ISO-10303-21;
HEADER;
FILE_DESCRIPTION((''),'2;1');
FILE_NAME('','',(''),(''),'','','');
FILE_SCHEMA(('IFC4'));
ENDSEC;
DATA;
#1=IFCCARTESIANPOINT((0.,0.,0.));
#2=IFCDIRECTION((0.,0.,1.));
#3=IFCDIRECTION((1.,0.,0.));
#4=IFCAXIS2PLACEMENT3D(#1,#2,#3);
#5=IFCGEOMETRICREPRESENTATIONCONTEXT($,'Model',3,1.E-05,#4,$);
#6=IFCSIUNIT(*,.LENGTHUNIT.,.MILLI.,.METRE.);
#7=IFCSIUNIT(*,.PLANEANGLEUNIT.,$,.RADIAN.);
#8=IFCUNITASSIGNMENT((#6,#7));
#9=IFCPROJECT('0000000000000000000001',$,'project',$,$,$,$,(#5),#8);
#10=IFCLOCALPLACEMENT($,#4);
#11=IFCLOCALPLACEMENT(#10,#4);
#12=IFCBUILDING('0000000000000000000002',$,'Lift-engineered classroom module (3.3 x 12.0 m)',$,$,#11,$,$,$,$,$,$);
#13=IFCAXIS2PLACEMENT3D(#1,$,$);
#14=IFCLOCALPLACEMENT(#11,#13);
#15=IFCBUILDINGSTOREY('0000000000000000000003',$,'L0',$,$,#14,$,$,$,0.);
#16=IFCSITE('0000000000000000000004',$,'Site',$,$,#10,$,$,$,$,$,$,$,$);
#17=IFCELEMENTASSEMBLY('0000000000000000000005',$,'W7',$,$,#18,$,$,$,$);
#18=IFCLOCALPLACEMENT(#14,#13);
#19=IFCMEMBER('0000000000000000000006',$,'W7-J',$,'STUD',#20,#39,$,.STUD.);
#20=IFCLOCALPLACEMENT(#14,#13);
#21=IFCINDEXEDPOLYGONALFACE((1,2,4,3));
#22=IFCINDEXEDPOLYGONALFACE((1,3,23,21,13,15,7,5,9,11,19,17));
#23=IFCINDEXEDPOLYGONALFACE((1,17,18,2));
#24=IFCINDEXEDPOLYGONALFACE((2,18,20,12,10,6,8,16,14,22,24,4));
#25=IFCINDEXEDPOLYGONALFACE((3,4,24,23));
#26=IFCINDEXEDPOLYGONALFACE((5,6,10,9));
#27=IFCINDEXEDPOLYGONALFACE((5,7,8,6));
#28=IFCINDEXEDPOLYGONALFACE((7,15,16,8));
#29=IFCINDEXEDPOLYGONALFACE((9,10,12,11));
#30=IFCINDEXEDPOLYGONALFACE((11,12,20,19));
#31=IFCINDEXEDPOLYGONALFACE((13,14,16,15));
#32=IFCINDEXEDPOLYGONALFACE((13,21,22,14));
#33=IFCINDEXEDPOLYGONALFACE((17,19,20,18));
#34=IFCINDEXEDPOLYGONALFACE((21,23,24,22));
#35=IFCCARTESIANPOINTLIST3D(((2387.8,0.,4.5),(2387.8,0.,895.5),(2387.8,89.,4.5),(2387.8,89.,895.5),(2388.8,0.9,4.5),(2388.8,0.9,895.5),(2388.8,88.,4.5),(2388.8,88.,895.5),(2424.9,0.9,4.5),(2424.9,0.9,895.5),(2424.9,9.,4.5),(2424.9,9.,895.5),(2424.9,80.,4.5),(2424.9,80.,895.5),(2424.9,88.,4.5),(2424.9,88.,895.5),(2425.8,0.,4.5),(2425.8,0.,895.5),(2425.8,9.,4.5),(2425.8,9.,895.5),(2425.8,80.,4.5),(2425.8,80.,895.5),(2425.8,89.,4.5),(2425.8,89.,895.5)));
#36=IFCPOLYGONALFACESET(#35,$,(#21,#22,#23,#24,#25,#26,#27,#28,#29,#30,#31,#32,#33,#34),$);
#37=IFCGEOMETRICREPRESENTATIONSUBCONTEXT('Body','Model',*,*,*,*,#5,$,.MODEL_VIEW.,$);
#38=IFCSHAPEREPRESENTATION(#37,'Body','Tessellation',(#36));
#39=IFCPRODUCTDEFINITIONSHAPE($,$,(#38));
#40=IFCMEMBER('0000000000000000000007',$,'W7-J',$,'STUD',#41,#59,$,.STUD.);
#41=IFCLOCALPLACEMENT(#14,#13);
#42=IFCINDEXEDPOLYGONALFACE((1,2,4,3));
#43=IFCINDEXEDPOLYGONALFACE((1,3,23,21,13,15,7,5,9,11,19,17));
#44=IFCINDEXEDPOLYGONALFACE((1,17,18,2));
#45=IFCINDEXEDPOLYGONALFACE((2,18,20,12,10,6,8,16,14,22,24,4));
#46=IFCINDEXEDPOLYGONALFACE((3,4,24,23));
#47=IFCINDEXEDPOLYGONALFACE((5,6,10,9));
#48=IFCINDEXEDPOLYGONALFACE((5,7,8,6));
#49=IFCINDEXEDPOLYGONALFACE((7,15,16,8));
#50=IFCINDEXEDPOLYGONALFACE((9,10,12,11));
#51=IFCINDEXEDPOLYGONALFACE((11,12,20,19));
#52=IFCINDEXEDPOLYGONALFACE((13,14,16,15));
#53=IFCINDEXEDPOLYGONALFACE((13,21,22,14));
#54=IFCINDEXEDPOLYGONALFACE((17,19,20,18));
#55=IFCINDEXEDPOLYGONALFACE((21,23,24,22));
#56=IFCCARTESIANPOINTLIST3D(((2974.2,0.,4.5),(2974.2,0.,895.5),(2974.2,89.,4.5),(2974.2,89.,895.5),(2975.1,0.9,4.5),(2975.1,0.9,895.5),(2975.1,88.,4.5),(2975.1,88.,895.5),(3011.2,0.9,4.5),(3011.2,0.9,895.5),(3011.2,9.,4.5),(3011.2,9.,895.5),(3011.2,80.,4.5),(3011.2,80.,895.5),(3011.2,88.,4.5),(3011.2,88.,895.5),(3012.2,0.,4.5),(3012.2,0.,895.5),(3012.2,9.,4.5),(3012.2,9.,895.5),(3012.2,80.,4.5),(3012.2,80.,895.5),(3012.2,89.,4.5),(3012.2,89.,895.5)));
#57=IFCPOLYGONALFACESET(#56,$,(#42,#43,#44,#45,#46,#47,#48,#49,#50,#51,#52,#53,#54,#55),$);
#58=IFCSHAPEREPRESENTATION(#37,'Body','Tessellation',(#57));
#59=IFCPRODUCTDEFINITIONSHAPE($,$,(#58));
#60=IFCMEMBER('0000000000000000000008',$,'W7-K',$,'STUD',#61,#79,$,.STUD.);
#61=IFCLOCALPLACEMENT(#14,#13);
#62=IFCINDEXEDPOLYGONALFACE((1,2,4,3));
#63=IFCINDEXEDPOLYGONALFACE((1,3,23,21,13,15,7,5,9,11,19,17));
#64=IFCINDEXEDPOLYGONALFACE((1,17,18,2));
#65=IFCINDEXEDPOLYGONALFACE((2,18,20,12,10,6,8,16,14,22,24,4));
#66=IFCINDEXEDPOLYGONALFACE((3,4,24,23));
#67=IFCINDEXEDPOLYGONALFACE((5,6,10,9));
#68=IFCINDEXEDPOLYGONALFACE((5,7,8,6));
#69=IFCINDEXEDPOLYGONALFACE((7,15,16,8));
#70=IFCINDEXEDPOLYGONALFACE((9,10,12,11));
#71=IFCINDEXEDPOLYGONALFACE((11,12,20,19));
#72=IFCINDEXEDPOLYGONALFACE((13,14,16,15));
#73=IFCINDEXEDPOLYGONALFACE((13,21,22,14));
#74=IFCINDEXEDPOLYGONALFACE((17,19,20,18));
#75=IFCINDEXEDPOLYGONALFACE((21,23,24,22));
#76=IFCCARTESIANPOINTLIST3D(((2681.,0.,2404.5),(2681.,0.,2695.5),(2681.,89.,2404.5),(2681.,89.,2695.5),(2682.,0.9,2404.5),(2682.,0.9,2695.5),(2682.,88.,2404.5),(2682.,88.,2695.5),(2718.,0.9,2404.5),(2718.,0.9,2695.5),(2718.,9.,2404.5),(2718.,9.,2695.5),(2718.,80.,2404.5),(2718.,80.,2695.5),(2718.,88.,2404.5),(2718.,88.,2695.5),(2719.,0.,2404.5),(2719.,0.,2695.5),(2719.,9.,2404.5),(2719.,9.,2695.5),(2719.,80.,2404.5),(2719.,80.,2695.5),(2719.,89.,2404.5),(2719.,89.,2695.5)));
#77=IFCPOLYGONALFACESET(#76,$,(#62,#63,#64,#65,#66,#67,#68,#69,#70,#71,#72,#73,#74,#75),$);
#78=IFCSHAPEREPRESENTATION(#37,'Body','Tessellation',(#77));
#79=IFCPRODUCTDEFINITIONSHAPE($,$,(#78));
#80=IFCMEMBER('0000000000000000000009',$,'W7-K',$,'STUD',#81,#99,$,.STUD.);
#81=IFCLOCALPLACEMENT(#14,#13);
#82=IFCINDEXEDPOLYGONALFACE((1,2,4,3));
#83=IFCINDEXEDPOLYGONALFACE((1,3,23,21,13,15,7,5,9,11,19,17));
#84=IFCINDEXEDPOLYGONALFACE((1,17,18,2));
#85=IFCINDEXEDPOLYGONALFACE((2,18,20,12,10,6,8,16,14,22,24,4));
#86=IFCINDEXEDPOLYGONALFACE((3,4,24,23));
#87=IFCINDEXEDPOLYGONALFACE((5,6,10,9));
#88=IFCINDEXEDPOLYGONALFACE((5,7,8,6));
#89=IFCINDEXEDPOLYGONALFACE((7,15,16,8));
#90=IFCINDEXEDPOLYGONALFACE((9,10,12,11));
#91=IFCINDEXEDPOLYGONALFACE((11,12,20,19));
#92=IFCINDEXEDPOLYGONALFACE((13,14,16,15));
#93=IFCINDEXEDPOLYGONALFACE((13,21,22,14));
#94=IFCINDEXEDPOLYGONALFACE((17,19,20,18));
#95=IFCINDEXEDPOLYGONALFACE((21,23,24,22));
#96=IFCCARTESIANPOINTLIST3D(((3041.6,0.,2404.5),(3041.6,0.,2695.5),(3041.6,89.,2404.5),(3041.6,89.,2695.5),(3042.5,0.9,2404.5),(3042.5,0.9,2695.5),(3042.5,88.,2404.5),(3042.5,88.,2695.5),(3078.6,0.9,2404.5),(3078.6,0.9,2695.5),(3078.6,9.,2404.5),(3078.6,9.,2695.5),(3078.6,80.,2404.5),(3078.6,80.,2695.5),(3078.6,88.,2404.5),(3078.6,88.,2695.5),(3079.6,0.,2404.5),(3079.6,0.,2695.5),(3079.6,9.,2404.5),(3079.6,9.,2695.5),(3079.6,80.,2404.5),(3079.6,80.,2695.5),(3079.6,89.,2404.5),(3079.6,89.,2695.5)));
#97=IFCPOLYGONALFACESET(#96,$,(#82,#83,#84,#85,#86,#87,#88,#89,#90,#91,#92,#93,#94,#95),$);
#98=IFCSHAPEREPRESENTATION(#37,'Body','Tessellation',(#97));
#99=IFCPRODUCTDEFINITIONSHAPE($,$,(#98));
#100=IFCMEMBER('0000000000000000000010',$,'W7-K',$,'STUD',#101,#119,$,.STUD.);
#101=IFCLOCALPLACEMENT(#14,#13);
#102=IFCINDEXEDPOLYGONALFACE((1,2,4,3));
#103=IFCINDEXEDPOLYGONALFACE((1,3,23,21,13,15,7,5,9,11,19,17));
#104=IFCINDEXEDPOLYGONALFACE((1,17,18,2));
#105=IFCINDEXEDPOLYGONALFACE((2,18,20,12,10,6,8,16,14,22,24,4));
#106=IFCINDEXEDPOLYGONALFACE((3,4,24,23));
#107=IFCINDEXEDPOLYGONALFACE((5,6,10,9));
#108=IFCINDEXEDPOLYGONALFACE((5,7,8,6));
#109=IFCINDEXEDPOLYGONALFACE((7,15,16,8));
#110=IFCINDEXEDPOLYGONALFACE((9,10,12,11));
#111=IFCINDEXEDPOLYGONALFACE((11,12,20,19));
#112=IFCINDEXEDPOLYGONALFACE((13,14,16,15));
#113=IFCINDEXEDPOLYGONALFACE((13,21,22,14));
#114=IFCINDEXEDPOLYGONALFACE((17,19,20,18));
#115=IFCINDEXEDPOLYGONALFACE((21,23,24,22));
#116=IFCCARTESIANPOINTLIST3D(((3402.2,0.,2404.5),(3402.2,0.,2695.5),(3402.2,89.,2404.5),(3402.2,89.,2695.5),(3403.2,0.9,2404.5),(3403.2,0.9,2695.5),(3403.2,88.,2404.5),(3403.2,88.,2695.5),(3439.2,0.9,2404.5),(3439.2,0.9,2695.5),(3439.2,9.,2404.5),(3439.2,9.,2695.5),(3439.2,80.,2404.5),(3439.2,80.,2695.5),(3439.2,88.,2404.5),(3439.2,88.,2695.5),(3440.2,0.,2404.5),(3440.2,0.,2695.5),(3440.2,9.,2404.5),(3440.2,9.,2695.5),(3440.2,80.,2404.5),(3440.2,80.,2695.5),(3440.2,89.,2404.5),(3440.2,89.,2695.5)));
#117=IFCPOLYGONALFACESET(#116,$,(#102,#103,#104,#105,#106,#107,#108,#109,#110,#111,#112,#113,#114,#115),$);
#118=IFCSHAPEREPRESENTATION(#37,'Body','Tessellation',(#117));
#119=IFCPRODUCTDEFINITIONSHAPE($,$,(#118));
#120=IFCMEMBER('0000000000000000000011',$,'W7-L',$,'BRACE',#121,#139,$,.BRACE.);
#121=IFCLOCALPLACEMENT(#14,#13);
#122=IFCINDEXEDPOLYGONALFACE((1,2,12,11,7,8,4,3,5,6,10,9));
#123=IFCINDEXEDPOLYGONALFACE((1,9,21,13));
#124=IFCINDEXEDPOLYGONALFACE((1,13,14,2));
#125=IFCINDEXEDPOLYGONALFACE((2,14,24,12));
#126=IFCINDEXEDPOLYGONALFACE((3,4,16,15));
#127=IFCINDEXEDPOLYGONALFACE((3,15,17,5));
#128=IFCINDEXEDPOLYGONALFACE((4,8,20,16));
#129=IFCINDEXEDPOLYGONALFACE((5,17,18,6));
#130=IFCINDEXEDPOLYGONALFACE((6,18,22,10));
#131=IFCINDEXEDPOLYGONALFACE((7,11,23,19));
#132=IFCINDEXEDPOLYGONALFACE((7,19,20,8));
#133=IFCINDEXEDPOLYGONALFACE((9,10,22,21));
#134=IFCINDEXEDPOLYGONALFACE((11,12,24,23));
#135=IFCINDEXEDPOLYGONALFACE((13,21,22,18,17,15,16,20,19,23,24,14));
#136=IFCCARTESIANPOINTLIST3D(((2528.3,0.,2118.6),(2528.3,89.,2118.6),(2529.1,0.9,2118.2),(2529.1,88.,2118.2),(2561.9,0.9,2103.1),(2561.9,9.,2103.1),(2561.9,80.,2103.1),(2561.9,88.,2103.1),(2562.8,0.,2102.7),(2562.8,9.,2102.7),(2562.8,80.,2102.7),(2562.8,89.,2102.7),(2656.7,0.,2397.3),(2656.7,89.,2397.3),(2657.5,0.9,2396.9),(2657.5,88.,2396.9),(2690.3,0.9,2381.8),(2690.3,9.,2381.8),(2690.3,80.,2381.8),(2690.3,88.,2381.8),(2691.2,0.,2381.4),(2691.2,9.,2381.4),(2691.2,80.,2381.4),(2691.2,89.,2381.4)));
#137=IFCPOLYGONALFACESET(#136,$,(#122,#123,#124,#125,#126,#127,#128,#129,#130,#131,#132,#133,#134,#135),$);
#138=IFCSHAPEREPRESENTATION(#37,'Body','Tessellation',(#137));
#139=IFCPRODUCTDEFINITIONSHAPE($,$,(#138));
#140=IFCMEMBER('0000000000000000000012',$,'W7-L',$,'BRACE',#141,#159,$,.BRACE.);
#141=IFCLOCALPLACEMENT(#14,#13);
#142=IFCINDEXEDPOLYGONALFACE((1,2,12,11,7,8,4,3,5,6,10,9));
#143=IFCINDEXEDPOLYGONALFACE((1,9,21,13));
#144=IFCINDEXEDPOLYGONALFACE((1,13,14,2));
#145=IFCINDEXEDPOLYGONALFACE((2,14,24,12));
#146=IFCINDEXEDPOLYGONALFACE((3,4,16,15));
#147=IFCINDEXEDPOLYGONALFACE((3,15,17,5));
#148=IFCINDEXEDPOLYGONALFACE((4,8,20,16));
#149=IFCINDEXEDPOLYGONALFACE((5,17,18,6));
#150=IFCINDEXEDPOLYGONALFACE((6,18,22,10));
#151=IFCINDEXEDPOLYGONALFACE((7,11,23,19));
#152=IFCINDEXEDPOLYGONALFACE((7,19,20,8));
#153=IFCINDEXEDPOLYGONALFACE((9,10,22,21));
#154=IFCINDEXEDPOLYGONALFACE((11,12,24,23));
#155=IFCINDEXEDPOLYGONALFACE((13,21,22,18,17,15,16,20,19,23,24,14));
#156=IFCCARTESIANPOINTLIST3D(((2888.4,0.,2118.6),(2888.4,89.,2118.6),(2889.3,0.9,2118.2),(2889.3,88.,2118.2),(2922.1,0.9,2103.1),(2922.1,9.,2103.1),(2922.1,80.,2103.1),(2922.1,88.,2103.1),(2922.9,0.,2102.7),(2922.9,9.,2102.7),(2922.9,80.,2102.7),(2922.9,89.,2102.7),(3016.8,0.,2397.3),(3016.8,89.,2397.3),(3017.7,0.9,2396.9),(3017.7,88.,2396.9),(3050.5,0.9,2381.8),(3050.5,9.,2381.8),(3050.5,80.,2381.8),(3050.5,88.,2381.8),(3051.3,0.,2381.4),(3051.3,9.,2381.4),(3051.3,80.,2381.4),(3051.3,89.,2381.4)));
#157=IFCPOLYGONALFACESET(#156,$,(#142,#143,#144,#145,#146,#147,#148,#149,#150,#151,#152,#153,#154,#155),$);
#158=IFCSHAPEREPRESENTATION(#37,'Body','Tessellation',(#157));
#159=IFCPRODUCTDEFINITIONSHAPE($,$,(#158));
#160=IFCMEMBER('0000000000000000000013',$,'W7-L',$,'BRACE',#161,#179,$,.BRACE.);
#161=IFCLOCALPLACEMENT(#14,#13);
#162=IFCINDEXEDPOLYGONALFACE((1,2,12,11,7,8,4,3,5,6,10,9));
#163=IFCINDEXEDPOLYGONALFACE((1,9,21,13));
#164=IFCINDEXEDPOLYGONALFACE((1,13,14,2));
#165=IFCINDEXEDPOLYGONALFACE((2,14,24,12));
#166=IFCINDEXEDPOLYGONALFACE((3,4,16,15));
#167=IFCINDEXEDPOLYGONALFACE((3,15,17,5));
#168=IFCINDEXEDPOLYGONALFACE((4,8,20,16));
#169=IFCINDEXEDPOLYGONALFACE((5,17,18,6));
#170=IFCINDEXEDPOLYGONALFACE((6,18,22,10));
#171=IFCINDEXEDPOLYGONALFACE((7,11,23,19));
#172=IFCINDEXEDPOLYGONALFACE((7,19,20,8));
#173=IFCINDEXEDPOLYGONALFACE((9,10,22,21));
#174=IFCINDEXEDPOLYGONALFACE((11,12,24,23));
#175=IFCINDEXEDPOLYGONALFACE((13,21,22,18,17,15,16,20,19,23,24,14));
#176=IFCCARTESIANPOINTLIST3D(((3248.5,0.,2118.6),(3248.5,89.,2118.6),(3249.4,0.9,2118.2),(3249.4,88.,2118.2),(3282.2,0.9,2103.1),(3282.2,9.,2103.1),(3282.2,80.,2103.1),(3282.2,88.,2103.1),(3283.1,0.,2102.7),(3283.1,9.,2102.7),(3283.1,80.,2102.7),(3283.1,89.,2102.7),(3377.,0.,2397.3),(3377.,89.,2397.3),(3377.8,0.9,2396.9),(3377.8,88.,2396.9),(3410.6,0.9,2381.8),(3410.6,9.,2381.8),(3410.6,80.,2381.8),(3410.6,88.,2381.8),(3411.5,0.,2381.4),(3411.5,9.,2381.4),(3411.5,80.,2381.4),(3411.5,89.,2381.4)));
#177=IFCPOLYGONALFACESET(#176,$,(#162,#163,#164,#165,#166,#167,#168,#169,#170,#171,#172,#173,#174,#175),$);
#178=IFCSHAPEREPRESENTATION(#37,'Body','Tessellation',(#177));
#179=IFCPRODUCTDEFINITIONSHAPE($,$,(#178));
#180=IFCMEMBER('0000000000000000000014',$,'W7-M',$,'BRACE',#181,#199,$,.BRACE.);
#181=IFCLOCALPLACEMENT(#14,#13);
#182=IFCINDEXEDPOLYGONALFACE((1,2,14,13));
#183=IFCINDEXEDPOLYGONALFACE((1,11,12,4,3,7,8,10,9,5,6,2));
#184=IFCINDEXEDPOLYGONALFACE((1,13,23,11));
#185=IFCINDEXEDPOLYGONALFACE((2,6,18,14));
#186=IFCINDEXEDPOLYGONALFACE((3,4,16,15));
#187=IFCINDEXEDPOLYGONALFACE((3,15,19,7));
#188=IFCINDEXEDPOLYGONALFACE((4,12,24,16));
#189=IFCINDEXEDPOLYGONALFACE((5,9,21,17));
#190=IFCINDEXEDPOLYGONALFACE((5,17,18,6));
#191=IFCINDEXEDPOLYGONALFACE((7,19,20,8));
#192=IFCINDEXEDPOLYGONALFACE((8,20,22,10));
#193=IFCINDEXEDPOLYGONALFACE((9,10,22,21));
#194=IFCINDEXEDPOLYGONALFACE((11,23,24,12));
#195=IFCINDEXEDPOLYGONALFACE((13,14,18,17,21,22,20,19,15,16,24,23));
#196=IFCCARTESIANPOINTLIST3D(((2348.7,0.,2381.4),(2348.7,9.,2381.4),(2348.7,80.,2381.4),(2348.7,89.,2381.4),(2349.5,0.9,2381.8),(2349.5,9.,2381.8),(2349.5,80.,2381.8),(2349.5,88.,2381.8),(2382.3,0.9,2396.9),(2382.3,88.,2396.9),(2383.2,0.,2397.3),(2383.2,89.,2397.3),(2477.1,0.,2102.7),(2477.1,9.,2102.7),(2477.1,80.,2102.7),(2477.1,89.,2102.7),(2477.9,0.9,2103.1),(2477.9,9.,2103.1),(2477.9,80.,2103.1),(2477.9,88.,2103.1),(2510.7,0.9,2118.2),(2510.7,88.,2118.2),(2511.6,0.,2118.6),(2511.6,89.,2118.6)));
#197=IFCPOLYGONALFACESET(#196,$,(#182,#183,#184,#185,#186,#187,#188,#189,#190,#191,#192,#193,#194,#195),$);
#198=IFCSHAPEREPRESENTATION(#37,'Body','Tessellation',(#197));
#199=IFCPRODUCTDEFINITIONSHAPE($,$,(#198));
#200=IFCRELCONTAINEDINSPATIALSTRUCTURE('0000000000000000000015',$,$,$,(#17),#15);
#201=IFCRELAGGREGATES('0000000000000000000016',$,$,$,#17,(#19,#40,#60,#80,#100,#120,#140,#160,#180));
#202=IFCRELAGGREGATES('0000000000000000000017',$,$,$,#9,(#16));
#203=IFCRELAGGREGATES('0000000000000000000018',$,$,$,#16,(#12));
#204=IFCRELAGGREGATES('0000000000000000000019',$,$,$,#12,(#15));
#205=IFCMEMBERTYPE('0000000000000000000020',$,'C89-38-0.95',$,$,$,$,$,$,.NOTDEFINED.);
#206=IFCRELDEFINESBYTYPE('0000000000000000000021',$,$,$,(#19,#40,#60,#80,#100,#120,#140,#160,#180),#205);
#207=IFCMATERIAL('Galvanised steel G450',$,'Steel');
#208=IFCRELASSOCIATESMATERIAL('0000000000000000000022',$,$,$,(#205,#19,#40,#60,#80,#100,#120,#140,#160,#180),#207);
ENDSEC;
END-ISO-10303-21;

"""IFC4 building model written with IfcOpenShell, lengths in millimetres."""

from ifc_helpers import new_model, si_unit, frame, origin, origin_with_axes, origin_2d, place, context, subcontext, project, spatial, c_section, extrude, material, material_profile, profile_set, profile_usage, type_object, element, aggregate, save


model = new_model("IFC4")

# Units and contexts
model_context = context("Model", 3, precision=1e-05, world=origin_with_axes())
body_context = subcontext(model_context, "Body", "Model", "MODEL_VIEW")
ifc_project = project(units=[si_unit("LENGTHUNIT", "METRE", prefix="MILLI"), si_unit("PLANEANGLEUNIT", "RADIAN")], contexts=[model_context])

# Site, building, storey
site_placement = place(None, origin_with_axes())
site = spatial("IfcSite", under=ifc_project, at=site_placement, Name="Site")
building_placement = place(site_placement, origin_with_axes())
building = spatial("IfcBuilding", under=site, at=building_placement, Name="Lift-engineered classroom module (3.3 x 12.0 m)")
storey_placement = place(building_placement, origin())
storey = spatial("IfcBuildingStorey", under=building, at=storey_placement, Name="L0", Elevation=0.0)

# Element assembly, members
assembly_1_placement = place(storey_placement, frame((900.0, 44.5, 0.0)))
assembly_1 = element("IfcElementAssembly", 1, at=assembly_1_placement, inside=storey, Name="W7")
ifc_material = material(Name="Galvanised steel G450", Category="Steel")
ifc_material_profile = material_profile(ifc_material, c_section(Depth=89.0, Width=38.0, WallThickness=0.9, Girth=9.0, at=origin_2d()), Name="C89-38-0.95")
ifc_profile_set = profile_set([ifc_material_profile], Name="C89-38-0.95")
ifc_profile_usage = profile_usage(ifc_profile_set)
member_type = type_object("IfcMemberType", Name="C89-38-0.95", PredefinedType="NOTDEFINED", material=ifc_profile_set)
member_1_placement = place(assembly_1_placement, frame((1506.8, 0.0, 895.5), z_axis=(0.0, 0.0, -1.0), x_axis=(1.0, 0.0, 0.0)))
member_1 = element("IfcMember", 2, at=member_1_placement, type_object=member_type, material=ifc_profile_usage, Name="W7-J", ObjectType="STUD", PredefinedType="STUD", context=body_context, shape_type="SweptSolid", body=[
    extrude(c_section(Depth=89.0, Width=38.0, WallThickness=0.9, Girth=9.0, at=origin_2d()), origin(), (0.0, 0.0, 1.0), 891.0),
])
member_2_placement = place(assembly_1_placement, frame((2093.2, 0.0, 895.5), z_axis=(0.0, 0.0, -1.0), x_axis=(1.0, 0.0, 0.0)))
member_2 = element("IfcMember", 3, at=member_2_placement, type_object=member_type, material=ifc_profile_usage, Name="W7-J", ObjectType="STUD", PredefinedType="STUD", context=body_context, shape_type="SweptSolid", body=[
    extrude(c_section(Depth=89.0, Width=38.0, WallThickness=0.9, Girth=9.0, at=origin_2d()), origin(), (0.0, 0.0, 1.0), 891.0),
])
member_3_placement = place(assembly_1_placement, frame((1800.0, 0.0, 2695.5), z_axis=(0.0, 0.0, -1.0), x_axis=(1.0, 0.0, 0.0)))
member_3 = element("IfcMember", 4, at=member_3_placement, type_object=member_type, material=ifc_profile_usage, Name="W7-K", ObjectType="STUD", PredefinedType="STUD", context=body_context, shape_type="SweptSolid", body=[
    extrude(c_section(Depth=89.0, Width=38.0, WallThickness=0.9, Girth=9.0, at=origin_2d()), origin(), (0.0, 0.0, 1.0), 291.0),
])
member_4_placement = place(assembly_1_placement, frame((2160.6, 0.0, 2695.5), z_axis=(0.0, 0.0, -1.0), x_axis=(1.0, 0.0, 0.0)))
member_4 = element("IfcMember", 5, at=member_4_placement, type_object=member_type, material=ifc_profile_usage, Name="W7-K", ObjectType="STUD", PredefinedType="STUD", context=body_context, shape_type="SweptSolid", body=[
    extrude(c_section(Depth=89.0, Width=38.0, WallThickness=0.9, Girth=9.0, at=origin_2d()), origin(), (0.0, 0.0, 1.0), 291.0),
])
member_5_placement = place(assembly_1_placement, frame((2521.2, 0.0, 2695.5), z_axis=(0.0, 0.0, -1.0), x_axis=(1.0, 0.0, 0.0)))
member_5 = element("IfcMember", 6, at=member_5_placement, type_object=member_type, material=ifc_profile_usage, Name="W7-K", ObjectType="STUD", PredefinedType="STUD", context=body_context, shape_type="SweptSolid", body=[
    extrude(c_section(Depth=89.0, Width=38.0, WallThickness=0.9, Girth=9.0, at=origin_2d()), origin(), (0.0, 0.0, 1.0), 291.0),
])
member_6_placement = place(assembly_1_placement, frame((1773.9, 0.0, 2389.3), z_axis=(-0.418465, 0.0, -0.908233), x_axis=(0.908233, 0.0, -0.418465)))
member_6 = element("IfcMember", 7, at=member_6_placement, type_object=member_type, material=ifc_profile_usage, Name="W7-L", ObjectType="BRACE", PredefinedType="BRACE", context=body_context, shape_type="SweptSolid", body=[
    extrude(c_section(Depth=89.0, Width=38.0, WallThickness=0.9, Girth=9.0, at=origin_2d()), origin(), (0.0, 0.0, 1.0), 306.9),
])
member_7_placement = place(assembly_1_placement, frame((2134.1, 0.0, 2389.3), z_axis=(-0.418465, 0.0, -0.908233), x_axis=(0.908233, 0.0, -0.418465)))
member_7 = element("IfcMember", 8, at=member_7_placement, type_object=member_type, material=ifc_profile_usage, Name="W7-L", ObjectType="BRACE", PredefinedType="BRACE", context=body_context, shape_type="SweptSolid", body=[
    extrude(c_section(Depth=89.0, Width=38.0, WallThickness=0.9, Girth=9.0, at=origin_2d()), origin(), (0.0, 0.0, 1.0), 306.9),
])
member_8_placement = place(assembly_1_placement, frame((2494.2, 0.0, 2389.3), z_axis=(-0.418465, 0.0, -0.908233), x_axis=(0.908233, 0.0, -0.418465)))
member_8 = element("IfcMember", 9, at=member_8_placement, type_object=member_type, material=ifc_profile_usage, Name="W7-L", ObjectType="BRACE", PredefinedType="BRACE", context=body_context, shape_type="SweptSolid", body=[
    extrude(c_section(Depth=89.0, Width=38.0, WallThickness=0.9, Girth=9.0, at=origin_2d()), origin(), (0.0, 0.0, 1.0), 306.9),
])
member_9_placement = place(assembly_1_placement, frame((1594.3, 0.0, 2110.6), z_axis=(-0.418465, 0.0, 0.908233), x_axis=(-0.908233, 0.0, -0.418465)))
member_9 = element("IfcMember", 10, at=member_9_placement, type_object=member_type, material=ifc_profile_usage, Name="W7-M", ObjectType="BRACE", PredefinedType="BRACE", context=body_context, shape_type="SweptSolid", body=[
    extrude(c_section(Depth=89.0, Width=38.0, WallThickness=0.9, Girth=9.0, at=origin_2d()), origin(), (0.0, 0.0, 1.0), 306.9),
])
aggregate(assembly_1, [member_1, member_2, member_3, member_4, member_5, member_6, member_7, member_8, member_9])

save(model, "model.ifc")
